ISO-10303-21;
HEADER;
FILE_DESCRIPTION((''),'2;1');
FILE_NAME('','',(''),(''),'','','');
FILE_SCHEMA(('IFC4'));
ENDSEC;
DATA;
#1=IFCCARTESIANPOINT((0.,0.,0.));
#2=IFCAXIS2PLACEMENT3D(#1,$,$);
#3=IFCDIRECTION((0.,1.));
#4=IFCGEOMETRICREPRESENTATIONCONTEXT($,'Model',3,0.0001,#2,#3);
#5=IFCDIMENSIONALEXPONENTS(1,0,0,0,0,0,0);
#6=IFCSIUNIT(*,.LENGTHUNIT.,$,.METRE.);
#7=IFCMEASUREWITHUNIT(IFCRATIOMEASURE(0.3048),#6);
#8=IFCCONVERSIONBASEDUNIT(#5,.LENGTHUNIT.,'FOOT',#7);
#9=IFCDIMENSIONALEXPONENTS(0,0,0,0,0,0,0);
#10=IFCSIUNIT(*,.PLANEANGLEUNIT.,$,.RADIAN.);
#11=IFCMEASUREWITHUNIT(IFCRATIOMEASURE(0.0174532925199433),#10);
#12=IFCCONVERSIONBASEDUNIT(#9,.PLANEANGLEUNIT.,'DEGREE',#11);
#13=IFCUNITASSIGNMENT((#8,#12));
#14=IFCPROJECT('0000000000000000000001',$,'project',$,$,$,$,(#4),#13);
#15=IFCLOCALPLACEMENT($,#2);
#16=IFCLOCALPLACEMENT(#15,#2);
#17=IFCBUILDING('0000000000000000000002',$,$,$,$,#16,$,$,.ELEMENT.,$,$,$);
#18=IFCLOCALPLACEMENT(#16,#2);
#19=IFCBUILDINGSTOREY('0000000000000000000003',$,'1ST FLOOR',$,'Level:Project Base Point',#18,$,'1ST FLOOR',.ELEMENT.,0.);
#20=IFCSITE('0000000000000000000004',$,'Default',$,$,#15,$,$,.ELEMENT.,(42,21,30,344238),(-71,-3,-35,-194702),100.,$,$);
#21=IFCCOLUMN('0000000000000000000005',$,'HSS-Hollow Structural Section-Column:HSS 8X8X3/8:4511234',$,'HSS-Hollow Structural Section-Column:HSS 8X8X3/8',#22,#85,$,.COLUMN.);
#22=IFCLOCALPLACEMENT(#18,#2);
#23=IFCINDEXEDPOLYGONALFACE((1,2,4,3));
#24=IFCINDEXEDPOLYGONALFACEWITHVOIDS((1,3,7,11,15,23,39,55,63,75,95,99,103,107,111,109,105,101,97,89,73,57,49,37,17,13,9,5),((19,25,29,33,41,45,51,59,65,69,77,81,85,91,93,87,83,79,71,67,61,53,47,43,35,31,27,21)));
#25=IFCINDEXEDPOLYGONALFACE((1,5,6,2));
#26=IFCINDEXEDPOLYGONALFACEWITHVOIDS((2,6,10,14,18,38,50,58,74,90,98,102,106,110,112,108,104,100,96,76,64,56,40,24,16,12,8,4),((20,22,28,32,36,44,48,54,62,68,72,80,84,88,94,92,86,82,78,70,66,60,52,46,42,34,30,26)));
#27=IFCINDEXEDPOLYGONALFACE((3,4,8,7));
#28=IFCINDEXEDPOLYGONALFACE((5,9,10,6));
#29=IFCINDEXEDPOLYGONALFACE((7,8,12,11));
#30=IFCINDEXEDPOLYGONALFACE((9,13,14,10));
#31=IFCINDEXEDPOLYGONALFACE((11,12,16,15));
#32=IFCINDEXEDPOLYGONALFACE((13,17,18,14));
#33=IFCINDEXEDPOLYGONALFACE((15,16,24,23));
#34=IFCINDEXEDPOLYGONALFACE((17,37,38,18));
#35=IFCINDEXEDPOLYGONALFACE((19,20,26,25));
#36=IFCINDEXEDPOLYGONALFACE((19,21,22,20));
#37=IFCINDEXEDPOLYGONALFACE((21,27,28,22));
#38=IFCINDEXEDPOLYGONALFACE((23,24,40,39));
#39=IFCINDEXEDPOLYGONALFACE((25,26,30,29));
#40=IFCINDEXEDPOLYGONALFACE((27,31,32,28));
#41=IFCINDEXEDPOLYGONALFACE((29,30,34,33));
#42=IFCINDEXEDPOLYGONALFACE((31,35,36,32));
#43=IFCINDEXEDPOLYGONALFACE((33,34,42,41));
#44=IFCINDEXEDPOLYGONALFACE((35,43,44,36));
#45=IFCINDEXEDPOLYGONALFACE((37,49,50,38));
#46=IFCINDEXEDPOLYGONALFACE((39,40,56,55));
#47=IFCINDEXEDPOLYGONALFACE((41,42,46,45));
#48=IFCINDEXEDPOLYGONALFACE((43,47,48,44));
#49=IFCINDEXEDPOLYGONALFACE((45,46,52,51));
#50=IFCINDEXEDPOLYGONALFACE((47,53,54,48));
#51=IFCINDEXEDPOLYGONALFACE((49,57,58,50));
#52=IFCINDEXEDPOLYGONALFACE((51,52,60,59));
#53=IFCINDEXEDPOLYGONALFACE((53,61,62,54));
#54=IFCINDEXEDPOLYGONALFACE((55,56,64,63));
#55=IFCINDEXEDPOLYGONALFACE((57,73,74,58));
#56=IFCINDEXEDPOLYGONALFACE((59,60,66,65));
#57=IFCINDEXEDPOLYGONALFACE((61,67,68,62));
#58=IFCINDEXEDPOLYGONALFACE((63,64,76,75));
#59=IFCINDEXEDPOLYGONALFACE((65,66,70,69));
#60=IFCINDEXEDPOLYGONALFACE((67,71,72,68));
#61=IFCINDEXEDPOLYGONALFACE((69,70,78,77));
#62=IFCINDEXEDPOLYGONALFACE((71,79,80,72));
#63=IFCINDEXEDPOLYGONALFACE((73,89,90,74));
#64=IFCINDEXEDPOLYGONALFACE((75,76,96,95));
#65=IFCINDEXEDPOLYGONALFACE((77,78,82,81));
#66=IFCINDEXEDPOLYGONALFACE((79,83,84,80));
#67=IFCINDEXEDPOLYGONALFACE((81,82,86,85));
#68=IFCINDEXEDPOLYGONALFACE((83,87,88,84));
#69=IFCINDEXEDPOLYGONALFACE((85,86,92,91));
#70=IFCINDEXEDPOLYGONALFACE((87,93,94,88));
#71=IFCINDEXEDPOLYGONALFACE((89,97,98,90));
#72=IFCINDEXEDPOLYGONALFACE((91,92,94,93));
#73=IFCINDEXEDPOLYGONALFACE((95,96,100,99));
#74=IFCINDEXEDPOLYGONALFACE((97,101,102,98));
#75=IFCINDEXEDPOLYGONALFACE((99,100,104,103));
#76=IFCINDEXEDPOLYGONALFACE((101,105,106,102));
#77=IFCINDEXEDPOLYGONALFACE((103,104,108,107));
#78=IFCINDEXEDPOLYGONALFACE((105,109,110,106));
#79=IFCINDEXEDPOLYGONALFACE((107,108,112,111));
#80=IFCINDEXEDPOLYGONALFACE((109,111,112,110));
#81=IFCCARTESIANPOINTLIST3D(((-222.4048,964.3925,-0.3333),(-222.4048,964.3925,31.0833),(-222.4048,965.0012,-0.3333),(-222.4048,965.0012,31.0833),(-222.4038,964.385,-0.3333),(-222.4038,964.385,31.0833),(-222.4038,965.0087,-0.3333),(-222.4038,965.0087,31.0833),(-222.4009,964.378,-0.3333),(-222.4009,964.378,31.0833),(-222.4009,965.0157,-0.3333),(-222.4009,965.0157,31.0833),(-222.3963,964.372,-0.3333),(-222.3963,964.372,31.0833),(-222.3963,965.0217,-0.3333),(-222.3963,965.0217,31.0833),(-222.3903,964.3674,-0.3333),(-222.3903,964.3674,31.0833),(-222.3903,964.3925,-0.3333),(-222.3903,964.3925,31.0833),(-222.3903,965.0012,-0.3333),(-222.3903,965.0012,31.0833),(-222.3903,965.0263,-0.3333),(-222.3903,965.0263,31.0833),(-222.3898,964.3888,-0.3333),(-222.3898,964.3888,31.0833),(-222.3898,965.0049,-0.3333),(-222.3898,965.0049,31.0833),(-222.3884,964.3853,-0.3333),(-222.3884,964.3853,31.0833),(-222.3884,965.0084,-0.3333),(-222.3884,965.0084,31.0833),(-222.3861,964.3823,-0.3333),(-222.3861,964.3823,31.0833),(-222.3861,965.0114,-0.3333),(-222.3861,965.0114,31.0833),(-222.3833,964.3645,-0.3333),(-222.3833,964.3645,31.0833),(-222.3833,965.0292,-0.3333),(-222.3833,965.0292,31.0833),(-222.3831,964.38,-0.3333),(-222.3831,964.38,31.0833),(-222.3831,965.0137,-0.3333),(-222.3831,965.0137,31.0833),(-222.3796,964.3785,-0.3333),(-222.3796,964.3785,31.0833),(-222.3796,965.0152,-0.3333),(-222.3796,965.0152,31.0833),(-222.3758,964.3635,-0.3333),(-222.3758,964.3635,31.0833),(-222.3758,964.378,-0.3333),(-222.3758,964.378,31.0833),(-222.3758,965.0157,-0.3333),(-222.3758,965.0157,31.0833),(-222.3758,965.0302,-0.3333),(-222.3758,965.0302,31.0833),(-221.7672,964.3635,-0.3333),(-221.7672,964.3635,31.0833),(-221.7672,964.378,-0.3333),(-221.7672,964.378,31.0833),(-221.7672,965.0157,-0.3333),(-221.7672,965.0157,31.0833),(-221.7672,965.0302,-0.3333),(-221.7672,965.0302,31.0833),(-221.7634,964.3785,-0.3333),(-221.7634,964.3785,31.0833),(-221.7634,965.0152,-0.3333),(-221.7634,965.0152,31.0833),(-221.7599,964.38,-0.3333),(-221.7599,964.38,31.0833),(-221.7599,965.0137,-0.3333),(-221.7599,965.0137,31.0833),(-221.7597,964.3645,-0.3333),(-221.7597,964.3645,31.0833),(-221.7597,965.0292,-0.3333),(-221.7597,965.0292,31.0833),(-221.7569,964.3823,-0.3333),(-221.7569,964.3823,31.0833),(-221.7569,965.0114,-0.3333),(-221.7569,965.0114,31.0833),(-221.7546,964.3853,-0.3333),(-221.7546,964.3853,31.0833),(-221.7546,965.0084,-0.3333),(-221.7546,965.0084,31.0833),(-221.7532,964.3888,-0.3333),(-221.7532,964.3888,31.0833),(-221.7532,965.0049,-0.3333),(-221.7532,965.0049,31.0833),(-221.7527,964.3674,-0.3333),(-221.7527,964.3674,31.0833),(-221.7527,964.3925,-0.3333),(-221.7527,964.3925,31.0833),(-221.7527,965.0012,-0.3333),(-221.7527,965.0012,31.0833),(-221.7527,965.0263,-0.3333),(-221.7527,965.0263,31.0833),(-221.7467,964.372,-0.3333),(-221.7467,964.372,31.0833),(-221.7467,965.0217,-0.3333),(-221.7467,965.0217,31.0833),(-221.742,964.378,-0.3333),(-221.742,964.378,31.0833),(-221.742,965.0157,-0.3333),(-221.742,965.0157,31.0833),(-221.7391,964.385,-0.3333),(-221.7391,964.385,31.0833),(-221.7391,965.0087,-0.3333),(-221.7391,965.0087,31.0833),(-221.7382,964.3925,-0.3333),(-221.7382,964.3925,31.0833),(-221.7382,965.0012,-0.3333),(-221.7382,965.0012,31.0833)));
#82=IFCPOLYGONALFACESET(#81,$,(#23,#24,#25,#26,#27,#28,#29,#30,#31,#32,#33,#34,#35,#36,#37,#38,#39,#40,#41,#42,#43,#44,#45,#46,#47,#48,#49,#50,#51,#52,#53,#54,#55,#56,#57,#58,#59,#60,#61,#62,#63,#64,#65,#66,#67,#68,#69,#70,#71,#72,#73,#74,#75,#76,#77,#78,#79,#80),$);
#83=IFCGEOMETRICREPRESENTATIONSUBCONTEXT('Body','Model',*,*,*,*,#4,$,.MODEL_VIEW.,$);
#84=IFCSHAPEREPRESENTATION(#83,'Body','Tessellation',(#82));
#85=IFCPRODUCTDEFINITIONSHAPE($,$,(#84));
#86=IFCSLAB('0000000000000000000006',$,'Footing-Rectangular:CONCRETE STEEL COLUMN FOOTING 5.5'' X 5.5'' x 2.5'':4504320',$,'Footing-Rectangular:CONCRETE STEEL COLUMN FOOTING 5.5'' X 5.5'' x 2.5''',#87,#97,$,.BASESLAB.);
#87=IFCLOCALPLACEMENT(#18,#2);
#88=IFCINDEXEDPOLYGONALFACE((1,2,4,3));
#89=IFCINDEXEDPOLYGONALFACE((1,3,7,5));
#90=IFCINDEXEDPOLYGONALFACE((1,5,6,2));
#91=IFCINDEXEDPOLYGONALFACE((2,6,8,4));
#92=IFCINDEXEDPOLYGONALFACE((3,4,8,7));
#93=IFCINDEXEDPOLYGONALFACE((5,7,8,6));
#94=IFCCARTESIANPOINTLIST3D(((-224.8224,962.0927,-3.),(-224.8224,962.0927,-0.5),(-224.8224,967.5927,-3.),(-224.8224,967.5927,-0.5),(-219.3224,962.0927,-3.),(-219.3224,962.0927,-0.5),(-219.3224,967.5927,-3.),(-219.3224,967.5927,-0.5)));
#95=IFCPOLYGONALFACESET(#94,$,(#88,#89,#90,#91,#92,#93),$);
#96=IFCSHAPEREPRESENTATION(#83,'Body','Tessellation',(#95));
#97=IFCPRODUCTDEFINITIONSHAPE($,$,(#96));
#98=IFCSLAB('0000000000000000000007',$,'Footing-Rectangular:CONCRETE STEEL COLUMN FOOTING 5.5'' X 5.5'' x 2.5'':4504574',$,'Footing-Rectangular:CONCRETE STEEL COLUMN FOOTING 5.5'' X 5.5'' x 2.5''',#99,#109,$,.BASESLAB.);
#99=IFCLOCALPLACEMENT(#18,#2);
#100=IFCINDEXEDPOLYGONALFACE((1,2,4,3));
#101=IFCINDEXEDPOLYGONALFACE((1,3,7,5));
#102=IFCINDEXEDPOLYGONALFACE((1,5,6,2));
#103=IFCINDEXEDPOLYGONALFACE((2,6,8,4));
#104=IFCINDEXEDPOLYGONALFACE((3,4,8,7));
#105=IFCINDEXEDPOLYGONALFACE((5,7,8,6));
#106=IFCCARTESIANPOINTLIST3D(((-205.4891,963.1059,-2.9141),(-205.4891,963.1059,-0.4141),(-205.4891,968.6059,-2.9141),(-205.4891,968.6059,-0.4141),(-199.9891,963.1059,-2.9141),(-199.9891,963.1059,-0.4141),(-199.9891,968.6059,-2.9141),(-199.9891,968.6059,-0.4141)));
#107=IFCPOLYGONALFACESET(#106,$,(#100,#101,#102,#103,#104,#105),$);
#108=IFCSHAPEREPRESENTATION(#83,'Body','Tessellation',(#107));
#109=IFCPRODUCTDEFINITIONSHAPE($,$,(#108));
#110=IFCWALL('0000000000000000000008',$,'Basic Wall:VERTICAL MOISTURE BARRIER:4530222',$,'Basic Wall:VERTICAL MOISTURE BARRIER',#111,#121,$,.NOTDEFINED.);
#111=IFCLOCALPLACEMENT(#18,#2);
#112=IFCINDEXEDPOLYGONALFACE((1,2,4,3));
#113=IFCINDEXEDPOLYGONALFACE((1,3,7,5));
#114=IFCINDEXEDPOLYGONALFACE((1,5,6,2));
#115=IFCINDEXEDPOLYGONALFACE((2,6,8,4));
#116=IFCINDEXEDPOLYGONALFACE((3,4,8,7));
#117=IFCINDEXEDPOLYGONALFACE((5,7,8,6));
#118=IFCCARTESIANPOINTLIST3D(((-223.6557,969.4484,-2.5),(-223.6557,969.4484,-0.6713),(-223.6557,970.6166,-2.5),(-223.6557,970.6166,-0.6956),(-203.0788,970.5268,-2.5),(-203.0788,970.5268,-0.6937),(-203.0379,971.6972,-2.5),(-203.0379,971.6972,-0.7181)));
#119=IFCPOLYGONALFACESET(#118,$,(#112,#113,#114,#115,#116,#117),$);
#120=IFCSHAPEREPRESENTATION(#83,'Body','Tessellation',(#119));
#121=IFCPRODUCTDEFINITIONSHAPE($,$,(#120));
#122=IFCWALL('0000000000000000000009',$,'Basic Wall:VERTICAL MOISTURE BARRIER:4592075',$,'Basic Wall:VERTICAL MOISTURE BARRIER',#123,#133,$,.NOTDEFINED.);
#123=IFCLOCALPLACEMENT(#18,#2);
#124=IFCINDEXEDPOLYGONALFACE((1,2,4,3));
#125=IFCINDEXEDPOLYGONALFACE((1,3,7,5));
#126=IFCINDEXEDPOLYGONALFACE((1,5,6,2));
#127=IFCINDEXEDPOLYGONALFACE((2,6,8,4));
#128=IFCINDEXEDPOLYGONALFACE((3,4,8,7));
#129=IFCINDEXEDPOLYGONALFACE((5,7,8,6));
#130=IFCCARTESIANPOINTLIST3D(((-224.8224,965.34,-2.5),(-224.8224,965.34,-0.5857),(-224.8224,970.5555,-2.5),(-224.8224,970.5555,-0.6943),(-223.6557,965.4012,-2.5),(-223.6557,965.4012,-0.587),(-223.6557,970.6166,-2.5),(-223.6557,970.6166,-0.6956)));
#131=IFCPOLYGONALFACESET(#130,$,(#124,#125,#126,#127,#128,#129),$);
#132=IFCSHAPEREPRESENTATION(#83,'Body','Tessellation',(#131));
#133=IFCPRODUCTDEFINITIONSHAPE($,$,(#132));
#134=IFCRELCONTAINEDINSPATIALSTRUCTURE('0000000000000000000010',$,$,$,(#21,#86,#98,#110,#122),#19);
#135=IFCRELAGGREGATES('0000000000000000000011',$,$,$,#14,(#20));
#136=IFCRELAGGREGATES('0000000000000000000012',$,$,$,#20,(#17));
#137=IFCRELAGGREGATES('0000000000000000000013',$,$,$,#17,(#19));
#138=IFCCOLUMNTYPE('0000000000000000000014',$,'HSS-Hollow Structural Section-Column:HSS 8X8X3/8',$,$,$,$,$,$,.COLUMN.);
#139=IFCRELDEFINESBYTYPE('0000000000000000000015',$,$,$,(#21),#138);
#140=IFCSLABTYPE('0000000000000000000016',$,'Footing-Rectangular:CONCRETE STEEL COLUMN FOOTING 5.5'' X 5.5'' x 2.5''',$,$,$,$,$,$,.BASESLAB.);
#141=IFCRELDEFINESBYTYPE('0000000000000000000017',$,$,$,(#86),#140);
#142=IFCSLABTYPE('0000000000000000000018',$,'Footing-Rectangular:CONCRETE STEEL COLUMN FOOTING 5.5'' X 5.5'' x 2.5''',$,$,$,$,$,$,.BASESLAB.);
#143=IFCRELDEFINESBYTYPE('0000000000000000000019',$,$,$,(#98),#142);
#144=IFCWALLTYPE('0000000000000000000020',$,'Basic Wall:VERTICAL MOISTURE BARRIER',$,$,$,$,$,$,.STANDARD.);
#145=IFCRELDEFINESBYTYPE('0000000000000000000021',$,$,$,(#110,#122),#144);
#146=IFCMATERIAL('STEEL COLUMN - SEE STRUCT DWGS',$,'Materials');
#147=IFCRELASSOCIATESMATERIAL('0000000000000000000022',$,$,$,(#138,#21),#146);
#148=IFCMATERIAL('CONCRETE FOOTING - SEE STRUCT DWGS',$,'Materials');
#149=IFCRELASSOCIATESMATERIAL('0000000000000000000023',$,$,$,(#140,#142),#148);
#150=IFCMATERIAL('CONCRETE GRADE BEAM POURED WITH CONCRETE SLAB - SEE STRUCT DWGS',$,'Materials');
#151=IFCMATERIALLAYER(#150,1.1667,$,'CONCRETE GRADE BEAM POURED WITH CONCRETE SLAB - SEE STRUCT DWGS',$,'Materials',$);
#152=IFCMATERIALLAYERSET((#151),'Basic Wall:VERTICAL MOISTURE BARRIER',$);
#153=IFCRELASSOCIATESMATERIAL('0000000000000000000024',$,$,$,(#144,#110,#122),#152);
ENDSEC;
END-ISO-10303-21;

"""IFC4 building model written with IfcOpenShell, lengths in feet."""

from ifc_helpers import new_model, entity, si_unit, converted_unit, direction, frame, frame_2d, origin, place, context, subcontext, project, spatial, polyline, circle_curve, parameter, trimmed, segment, composite_curve, rectangle, outline, extrude, clip, bounded_halfspace, source, transform, mapped, material, layer, layer_set, layer_usage, material_profile, profile_set, profile_usage, type_object, type_shapes, element, save


model = new_model("IFC4")

# Units and contexts
model_context = context("Model", 3, precision=0.0001, world=origin(), true_north=direction((0.0, 1.0)))
body_context = subcontext(model_context, "Body", "Model", "MODEL_VIEW")
ifc_project = project(units=[converted_unit("LENGTHUNIT", "FOOT", entity("IfcRatioMeasure", 0.3048), si_unit("LENGTHUNIT", "METRE"), dimensions=[1, 0, 0, 0, 0, 0, 0]), converted_unit("PLANEANGLEUNIT", "DEGREE", entity("IfcRatioMeasure", 0.0174532925199433), si_unit("PLANEANGLEUNIT", "RADIAN"), dimensions=[0, 0, 0, 0, 0, 0, 0])], contexts=[model_context])

# Site, building, storey
site_placement = place(None, origin())
site = spatial("IfcSite", under=ifc_project, at=site_placement, Name="Default", CompositionType="ELEMENT", RefLatitude=(42, 21, 30, 344238), RefLongitude=(-71, -3, -35, -194702), RefElevation=100.0)
building_placement = place(site_placement, origin())
building = spatial("IfcBuilding", under=site, at=building_placement, CompositionType="ELEMENT")
storey_placement = place(building_placement, origin())
storey = spatial("IfcBuildingStorey", under=building, at=storey_placement, Name="1ST FLOOR", ObjectType="Level:Project Base Point", LongName="1ST FLOOR", CompositionType="ELEMENT", Elevation=0.0)

# Column
ifc_material_1 = material(Name="STEEL COLUMN - SEE STRUCT DWGS", Category="Materials")
ifc_material_profile_1 = material_profile(ifc_material_1, outline(composite_curve([segment(polyline([(-0.3043, -0.3333), (0.3043, -0.3333)]), True, "CONTINUOUS"), segment(trimmed(circle_curve(frame_2d((0.3043, -0.3043), x_axis=(-1.0, 0.0)), 0.029), [parameter(90.0)], [parameter(180.0)], True, "PARAMETER"), True, "CONTINUOUS"), segment(polyline([(0.3333, -0.3043), (0.3333, 0.3043)]), True, "CONTINUOUS"), segment(trimmed(circle_curve(frame_2d((0.3043, 0.3043), x_axis=(-1.0, 0.0)), 0.029), [parameter(180.0)], [parameter(270.0)], True, "PARAMETER"), True, "CONTINUOUS"), segment(polyline([(0.3043, 0.3333), (-0.3043, 0.3333)]), True, "CONTINUOUS"), segment(trimmed(circle_curve(frame_2d((-0.3043, 0.3043), x_axis=(-1.0, 0.0)), 0.029), [parameter(270.0)], [parameter(360.0)], True, "PARAMETER"), True, "CONTINUOUS"), segment(polyline([(-0.3333, 0.3043), (-0.3333, -0.3043)]), True, "CONTINUOUS"), segment(trimmed(circle_curve(frame_2d((-0.3043, -0.3043), x_axis=(-1.0, 0.0)), 0.029), [parameter(360.0)], [parameter(90.0)], True, "PARAMETER"), True, "CONTINUOUS")], self_intersect=False), holes=[composite_curve([segment(trimmed(circle_curve(frame_2d((-0.3043, -0.3043), x_axis=(-1.0, 0.0)), 0.0145), [parameter(0.0)], [parameter(90.0)], True, "PARAMETER"), False, "CONTINUOUS"), segment(polyline([(-0.3188, -0.3043), (-0.3188, 0.3043)]), True, "CONTINUOUS"), segment(trimmed(circle_curve(frame_2d((-0.3043, 0.3043), x_axis=(-1.0, 0.0)), 0.0145), [parameter(270.0)], [parameter(0.0)], True, "PARAMETER"), False, "CONTINUOUS"), segment(polyline([(-0.3043, 0.3188), (0.3043, 0.3188)]), True, "CONTINUOUS"), segment(trimmed(circle_curve(frame_2d((0.3043, 0.3043), x_axis=(-1.0, 0.0)), 0.0145), [parameter(180.0)], [parameter(270.0)], True, "PARAMETER"), False, "CONTINUOUS"), segment(polyline([(0.3188, 0.3043), (0.3188, -0.3043)]), True, "CONTINUOUS"), segment(trimmed(circle_curve(frame_2d((0.3043, -0.3043), x_axis=(-1.0, 0.0)), 0.0145), [parameter(90.0)], [parameter(180.0)], True, "PARAMETER"), False, "CONTINUOUS"), segment(polyline([(0.3043, -0.3188), (-0.3043, -0.3188)]), True, "CONTINUOUS")], self_intersect=False)]), Name="HSS 8X8X3/8")
ifc_profile_set_1 = profile_set([ifc_material_profile_1], Name="HSS 8X8X3/8")
ifc_profile_usage_1 = profile_usage(ifc_profile_set_1)
column_type_1 = type_object("IfcColumnType", Name="HSS-Hollow Structural Section-Column:HSS 8X8X3/8", PredefinedType="COLUMN", material=ifc_profile_set_1)
shared_shape_1 = source(origin(), body_context, "Body", "SweptSolid", [
    extrude(outline(composite_curve([segment(trimmed(circle_curve(frame_2d((0.3043, -0.3043), x_axis=(1.0, 0.0)), 0.029), [parameter(270.0)], [parameter(0.0)], True, "PARAMETER"), True, "CONTINUOUS"), segment(polyline([(0.3333, -0.3043), (0.3333, 0.3043)]), True, "CONTINUOUS"), segment(trimmed(circle_curve(frame_2d((0.3043, 0.3043), x_axis=(1.0, 0.0)), 0.029), [parameter(0.0)], [parameter(90.0)], True, "PARAMETER"), True, "CONTINUOUS"), segment(polyline([(0.3043, 0.3333), (-0.3043, 0.3333)]), True, "CONTINUOUS"), segment(trimmed(circle_curve(frame_2d((-0.3043, 0.3043), x_axis=(1.0, 0.0)), 0.029), [parameter(90.0)], [parameter(180.0)], True, "PARAMETER"), True, "CONTINUOUS"), segment(polyline([(-0.3333, 0.3043), (-0.3333, -0.3043)]), True, "CONTINUOUS"), segment(trimmed(circle_curve(frame_2d((-0.3043, -0.3043), x_axis=(1.0, 0.0)), 0.029), [parameter(180.0)], [parameter(270.0)], True, "PARAMETER"), True, "CONTINUOUS"), segment(polyline([(-0.3043, -0.3333), (0.3043, -0.3333)]), True, "CONTINUOUS")], self_intersect=False), holes=[composite_curve([segment(polyline([(0.3043, -0.3188), (-0.3043, -0.3188)]), True, "CONTINUOUS"), segment(trimmed(circle_curve(frame_2d((-0.3043, -0.3043), x_axis=(1.0, 0.0)), 0.0145), [parameter(180.0)], [parameter(270.0)], True, "PARAMETER"), False, "CONTINUOUS"), segment(polyline([(-0.3188, -0.3043), (-0.3188, 0.3043)]), True, "CONTINUOUS"), segment(trimmed(circle_curve(frame_2d((-0.3043, 0.3043), x_axis=(1.0, 0.0)), 0.0145), [parameter(90.0)], [parameter(180.0)], True, "PARAMETER"), False, "CONTINUOUS"), segment(polyline([(-0.3043, 0.3188), (0.3043, 0.3188)]), True, "CONTINUOUS"), segment(trimmed(circle_curve(frame_2d((0.3043, 0.3043), x_axis=(1.0, 0.0)), 0.0145), [parameter(0.0)], [parameter(90.0)], True, "PARAMETER"), False, "CONTINUOUS"), segment(polyline([(0.3188, 0.3043), (0.3188, -0.3043)]), True, "CONTINUOUS"), segment(trimmed(circle_curve(frame_2d((0.3043, -0.3043), x_axis=(1.0, 0.0)), 0.0145), [parameter(270.0)], [parameter(0.0)], True, "PARAMETER"), False, "CONTINUOUS")], self_intersect=False)]), frame((0.0, 0.0, -0.3333)), (0.0, 0.0, 1.0), 31.4167),
])
type_shapes(column_type_1, [shared_shape_1])
column_1_placement = place(storey_placement, frame((-222.0715, 964.6969, 0.0), z_axis=(0.0, 0.0, 1.0), x_axis=(-1.0, 0.0, 0.0)))
element("IfcColumn", 1, at=column_1_placement, inside=storey, type_object=column_type_1, material=ifc_profile_usage_1, Name="HSS-Hollow Structural Section-Column:HSS 8X8X3/8:4511234", ObjectType="HSS-Hollow Structural Section-Column:HSS 8X8X3/8", PredefinedType="COLUMN", context=body_context, shape_type="MappedRepresentation", body=[
    mapped(shared_shape_1, transform((0.0, 0.0, 0.0), scale=1.0)),
])

# Slabs
ifc_material_2 = material(Name="CONCRETE FOOTING - SEE STRUCT DWGS", Category="Materials")
slab_type_1 = type_object("IfcSlabType", Name="Footing-Rectangular:CONCRETE STEEL COLUMN FOOTING 5.5' X 5.5' x 2.5'", PredefinedType="BASESLAB", material=ifc_material_2)
slab_1_placement = place(storey_placement, frame((-224.8224, 962.0927, -3.0)))
element("IfcSlab", 2, at=slab_1_placement, inside=storey, type_object=slab_type_1, Name="Footing-Rectangular:CONCRETE STEEL COLUMN FOOTING 5.5' X 5.5' x 2.5':4504320", ObjectType="Footing-Rectangular:CONCRETE STEEL COLUMN FOOTING 5.5' X 5.5' x 2.5'", PredefinedType="BASESLAB", context=body_context, shape_type="SweptSolid", body=[
    extrude(rectangle(XDim=5.5, YDim=5.5, at=frame_2d((0.0, 0.0), x_axis=(1.0, 0.0))), frame((2.75, 2.75, 0.0), z_axis=(0.0, 0.0, 1.0), x_axis=(-1.0, 0.0, 0.0)), (0.0, 0.0, 1.0), 2.5),
])
slab_type_2 = type_object("IfcSlabType", Name="Footing-Rectangular:CONCRETE STEEL COLUMN FOOTING 5.5' X 5.5' x 2.5'", PredefinedType="BASESLAB", material=ifc_material_2)
slab_2_placement = place(storey_placement, frame((-205.4891, 963.1059, -2.9141)))
element("IfcSlab", 3, at=slab_2_placement, inside=storey, type_object=slab_type_2, Name="Footing-Rectangular:CONCRETE STEEL COLUMN FOOTING 5.5' X 5.5' x 2.5':4504574", ObjectType="Footing-Rectangular:CONCRETE STEEL COLUMN FOOTING 5.5' X 5.5' x 2.5'", PredefinedType="BASESLAB", context=body_context, shape_type="SweptSolid", body=[
    extrude(rectangle(XDim=5.5, YDim=5.5, at=frame_2d((0.0, 0.0), x_axis=(1.0, 0.0))), frame((2.75, 2.75, 0.0), z_axis=(0.0, 0.0, 1.0), x_axis=(-1.0, 0.0, 0.0)), (0.0, 0.0, 1.0), 2.5),
])

# Walls
ifc_material_3 = material(Name="CONCRETE GRADE BEAM POURED WITH CONCRETE SLAB - SEE STRUCT DWGS", Category="Materials")
ifc_layer_1 = layer(ifc_material_3, 1.1667, Name="CONCRETE GRADE BEAM POURED WITH CONCRETE SLAB - SEE STRUCT DWGS", Category="Materials")
ifc_layer_set_1 = layer_set([ifc_layer_1], Name="Basic Wall:VERTICAL MOISTURE BARRIER")
ifc_layer_usage_1 = layer_usage(ifc_layer_set_1, "AXIS2", "NEGATIVE", 0.5833)
wall_type_1 = type_object("IfcWallType", Name="Basic Wall:VERTICAL MOISTURE BARRIER", PredefinedType="STANDARD", material=ifc_layer_set_1)
wall_1_placement = place(storey_placement, frame((-223.6863, 970.0309, -2.5), z_axis=(0.0, 0.0, 1.0), x_axis=(0.99863, 0.052336, 0.0)))
element("IfcWall", 4, at=wall_1_placement, inside=storey, type_object=wall_type_1, material=ifc_layer_usage_1, Name="Basic Wall:VERTICAL MOISTURE BARRIER:4530222", ObjectType="Basic Wall:VERTICAL MOISTURE BARRIER", PredefinedType="NOTDEFINED", context=body_context, shape_type="Clipping", body=[
    clip(extrude(outline(polyline([(20.6052, -0.5833), (20.7073, 0.5833), (0.0611, 0.5833), (0.0, -0.5833), (10.3484, -0.5833), (11.5167, -0.5833), (19.4442, -0.5833), (20.6052, -0.5833)])), origin(), (0.0, 0.0, 1.0), 1.8287), bounded_halfspace(frame((0.0, -0.5833, 1.8287), z_axis=(-0.00109, -0.0208, -0.999783), x_axis=(-0.052325, -0.998413, 0.020829)), True, frame((0.0, -0.5833, 1.8287)), polyline([(0.0, 0.0), (10.3484, 0.0), (11.5167, 0.0), (19.4442, 0.0), (20.6052, 0.0), (20.7073, 1.1667), (0.0611, 1.1667), (0.0, 0.0)]))),
])
ifc_layer_usage_2 = layer_usage(ifc_layer_set_1, "AXIS2", "NEGATIVE", 0.5833)
wall_2_placement = place(storey_placement, frame((-224.2391, 965.34, -2.5), z_axis=(0.0, 0.0, 1.0), x_axis=(0.0, 1.0, 0.0)))
element("IfcWall", 5, at=wall_2_placement, inside=storey, type_object=wall_type_1, material=ifc_layer_usage_2, Name="Basic Wall:VERTICAL MOISTURE BARRIER:4592075", ObjectType="Basic Wall:VERTICAL MOISTURE BARRIER", PredefinedType="NOTDEFINED", context=body_context, shape_type="Clipping", body=[
    clip(extrude(outline(polyline([(5.2766, -0.5833), (5.2155, 0.5833), (0.0, 0.5833), (0.0611, -0.5833), (4.1084, -0.5833), (5.2766, -0.5833)])), origin(), (0.0, 0.0, 1.0), 1.9143), bounded_halfspace(frame((0.0611, -0.5833, 1.913), z_axis=(-0.020829, 0.0, -0.999783), x_axis=(-0.999783, 0.0, 0.020829)), True, frame((0.0611, -0.5833, 1.913)), polyline([(0.0, 0.0), (4.0472, 0.0), (5.2155, 0.0), (5.1543, 1.1667), (-0.0611, 1.1667), (0.0, 0.0)]))),
])

save(model, "model.ifc")
